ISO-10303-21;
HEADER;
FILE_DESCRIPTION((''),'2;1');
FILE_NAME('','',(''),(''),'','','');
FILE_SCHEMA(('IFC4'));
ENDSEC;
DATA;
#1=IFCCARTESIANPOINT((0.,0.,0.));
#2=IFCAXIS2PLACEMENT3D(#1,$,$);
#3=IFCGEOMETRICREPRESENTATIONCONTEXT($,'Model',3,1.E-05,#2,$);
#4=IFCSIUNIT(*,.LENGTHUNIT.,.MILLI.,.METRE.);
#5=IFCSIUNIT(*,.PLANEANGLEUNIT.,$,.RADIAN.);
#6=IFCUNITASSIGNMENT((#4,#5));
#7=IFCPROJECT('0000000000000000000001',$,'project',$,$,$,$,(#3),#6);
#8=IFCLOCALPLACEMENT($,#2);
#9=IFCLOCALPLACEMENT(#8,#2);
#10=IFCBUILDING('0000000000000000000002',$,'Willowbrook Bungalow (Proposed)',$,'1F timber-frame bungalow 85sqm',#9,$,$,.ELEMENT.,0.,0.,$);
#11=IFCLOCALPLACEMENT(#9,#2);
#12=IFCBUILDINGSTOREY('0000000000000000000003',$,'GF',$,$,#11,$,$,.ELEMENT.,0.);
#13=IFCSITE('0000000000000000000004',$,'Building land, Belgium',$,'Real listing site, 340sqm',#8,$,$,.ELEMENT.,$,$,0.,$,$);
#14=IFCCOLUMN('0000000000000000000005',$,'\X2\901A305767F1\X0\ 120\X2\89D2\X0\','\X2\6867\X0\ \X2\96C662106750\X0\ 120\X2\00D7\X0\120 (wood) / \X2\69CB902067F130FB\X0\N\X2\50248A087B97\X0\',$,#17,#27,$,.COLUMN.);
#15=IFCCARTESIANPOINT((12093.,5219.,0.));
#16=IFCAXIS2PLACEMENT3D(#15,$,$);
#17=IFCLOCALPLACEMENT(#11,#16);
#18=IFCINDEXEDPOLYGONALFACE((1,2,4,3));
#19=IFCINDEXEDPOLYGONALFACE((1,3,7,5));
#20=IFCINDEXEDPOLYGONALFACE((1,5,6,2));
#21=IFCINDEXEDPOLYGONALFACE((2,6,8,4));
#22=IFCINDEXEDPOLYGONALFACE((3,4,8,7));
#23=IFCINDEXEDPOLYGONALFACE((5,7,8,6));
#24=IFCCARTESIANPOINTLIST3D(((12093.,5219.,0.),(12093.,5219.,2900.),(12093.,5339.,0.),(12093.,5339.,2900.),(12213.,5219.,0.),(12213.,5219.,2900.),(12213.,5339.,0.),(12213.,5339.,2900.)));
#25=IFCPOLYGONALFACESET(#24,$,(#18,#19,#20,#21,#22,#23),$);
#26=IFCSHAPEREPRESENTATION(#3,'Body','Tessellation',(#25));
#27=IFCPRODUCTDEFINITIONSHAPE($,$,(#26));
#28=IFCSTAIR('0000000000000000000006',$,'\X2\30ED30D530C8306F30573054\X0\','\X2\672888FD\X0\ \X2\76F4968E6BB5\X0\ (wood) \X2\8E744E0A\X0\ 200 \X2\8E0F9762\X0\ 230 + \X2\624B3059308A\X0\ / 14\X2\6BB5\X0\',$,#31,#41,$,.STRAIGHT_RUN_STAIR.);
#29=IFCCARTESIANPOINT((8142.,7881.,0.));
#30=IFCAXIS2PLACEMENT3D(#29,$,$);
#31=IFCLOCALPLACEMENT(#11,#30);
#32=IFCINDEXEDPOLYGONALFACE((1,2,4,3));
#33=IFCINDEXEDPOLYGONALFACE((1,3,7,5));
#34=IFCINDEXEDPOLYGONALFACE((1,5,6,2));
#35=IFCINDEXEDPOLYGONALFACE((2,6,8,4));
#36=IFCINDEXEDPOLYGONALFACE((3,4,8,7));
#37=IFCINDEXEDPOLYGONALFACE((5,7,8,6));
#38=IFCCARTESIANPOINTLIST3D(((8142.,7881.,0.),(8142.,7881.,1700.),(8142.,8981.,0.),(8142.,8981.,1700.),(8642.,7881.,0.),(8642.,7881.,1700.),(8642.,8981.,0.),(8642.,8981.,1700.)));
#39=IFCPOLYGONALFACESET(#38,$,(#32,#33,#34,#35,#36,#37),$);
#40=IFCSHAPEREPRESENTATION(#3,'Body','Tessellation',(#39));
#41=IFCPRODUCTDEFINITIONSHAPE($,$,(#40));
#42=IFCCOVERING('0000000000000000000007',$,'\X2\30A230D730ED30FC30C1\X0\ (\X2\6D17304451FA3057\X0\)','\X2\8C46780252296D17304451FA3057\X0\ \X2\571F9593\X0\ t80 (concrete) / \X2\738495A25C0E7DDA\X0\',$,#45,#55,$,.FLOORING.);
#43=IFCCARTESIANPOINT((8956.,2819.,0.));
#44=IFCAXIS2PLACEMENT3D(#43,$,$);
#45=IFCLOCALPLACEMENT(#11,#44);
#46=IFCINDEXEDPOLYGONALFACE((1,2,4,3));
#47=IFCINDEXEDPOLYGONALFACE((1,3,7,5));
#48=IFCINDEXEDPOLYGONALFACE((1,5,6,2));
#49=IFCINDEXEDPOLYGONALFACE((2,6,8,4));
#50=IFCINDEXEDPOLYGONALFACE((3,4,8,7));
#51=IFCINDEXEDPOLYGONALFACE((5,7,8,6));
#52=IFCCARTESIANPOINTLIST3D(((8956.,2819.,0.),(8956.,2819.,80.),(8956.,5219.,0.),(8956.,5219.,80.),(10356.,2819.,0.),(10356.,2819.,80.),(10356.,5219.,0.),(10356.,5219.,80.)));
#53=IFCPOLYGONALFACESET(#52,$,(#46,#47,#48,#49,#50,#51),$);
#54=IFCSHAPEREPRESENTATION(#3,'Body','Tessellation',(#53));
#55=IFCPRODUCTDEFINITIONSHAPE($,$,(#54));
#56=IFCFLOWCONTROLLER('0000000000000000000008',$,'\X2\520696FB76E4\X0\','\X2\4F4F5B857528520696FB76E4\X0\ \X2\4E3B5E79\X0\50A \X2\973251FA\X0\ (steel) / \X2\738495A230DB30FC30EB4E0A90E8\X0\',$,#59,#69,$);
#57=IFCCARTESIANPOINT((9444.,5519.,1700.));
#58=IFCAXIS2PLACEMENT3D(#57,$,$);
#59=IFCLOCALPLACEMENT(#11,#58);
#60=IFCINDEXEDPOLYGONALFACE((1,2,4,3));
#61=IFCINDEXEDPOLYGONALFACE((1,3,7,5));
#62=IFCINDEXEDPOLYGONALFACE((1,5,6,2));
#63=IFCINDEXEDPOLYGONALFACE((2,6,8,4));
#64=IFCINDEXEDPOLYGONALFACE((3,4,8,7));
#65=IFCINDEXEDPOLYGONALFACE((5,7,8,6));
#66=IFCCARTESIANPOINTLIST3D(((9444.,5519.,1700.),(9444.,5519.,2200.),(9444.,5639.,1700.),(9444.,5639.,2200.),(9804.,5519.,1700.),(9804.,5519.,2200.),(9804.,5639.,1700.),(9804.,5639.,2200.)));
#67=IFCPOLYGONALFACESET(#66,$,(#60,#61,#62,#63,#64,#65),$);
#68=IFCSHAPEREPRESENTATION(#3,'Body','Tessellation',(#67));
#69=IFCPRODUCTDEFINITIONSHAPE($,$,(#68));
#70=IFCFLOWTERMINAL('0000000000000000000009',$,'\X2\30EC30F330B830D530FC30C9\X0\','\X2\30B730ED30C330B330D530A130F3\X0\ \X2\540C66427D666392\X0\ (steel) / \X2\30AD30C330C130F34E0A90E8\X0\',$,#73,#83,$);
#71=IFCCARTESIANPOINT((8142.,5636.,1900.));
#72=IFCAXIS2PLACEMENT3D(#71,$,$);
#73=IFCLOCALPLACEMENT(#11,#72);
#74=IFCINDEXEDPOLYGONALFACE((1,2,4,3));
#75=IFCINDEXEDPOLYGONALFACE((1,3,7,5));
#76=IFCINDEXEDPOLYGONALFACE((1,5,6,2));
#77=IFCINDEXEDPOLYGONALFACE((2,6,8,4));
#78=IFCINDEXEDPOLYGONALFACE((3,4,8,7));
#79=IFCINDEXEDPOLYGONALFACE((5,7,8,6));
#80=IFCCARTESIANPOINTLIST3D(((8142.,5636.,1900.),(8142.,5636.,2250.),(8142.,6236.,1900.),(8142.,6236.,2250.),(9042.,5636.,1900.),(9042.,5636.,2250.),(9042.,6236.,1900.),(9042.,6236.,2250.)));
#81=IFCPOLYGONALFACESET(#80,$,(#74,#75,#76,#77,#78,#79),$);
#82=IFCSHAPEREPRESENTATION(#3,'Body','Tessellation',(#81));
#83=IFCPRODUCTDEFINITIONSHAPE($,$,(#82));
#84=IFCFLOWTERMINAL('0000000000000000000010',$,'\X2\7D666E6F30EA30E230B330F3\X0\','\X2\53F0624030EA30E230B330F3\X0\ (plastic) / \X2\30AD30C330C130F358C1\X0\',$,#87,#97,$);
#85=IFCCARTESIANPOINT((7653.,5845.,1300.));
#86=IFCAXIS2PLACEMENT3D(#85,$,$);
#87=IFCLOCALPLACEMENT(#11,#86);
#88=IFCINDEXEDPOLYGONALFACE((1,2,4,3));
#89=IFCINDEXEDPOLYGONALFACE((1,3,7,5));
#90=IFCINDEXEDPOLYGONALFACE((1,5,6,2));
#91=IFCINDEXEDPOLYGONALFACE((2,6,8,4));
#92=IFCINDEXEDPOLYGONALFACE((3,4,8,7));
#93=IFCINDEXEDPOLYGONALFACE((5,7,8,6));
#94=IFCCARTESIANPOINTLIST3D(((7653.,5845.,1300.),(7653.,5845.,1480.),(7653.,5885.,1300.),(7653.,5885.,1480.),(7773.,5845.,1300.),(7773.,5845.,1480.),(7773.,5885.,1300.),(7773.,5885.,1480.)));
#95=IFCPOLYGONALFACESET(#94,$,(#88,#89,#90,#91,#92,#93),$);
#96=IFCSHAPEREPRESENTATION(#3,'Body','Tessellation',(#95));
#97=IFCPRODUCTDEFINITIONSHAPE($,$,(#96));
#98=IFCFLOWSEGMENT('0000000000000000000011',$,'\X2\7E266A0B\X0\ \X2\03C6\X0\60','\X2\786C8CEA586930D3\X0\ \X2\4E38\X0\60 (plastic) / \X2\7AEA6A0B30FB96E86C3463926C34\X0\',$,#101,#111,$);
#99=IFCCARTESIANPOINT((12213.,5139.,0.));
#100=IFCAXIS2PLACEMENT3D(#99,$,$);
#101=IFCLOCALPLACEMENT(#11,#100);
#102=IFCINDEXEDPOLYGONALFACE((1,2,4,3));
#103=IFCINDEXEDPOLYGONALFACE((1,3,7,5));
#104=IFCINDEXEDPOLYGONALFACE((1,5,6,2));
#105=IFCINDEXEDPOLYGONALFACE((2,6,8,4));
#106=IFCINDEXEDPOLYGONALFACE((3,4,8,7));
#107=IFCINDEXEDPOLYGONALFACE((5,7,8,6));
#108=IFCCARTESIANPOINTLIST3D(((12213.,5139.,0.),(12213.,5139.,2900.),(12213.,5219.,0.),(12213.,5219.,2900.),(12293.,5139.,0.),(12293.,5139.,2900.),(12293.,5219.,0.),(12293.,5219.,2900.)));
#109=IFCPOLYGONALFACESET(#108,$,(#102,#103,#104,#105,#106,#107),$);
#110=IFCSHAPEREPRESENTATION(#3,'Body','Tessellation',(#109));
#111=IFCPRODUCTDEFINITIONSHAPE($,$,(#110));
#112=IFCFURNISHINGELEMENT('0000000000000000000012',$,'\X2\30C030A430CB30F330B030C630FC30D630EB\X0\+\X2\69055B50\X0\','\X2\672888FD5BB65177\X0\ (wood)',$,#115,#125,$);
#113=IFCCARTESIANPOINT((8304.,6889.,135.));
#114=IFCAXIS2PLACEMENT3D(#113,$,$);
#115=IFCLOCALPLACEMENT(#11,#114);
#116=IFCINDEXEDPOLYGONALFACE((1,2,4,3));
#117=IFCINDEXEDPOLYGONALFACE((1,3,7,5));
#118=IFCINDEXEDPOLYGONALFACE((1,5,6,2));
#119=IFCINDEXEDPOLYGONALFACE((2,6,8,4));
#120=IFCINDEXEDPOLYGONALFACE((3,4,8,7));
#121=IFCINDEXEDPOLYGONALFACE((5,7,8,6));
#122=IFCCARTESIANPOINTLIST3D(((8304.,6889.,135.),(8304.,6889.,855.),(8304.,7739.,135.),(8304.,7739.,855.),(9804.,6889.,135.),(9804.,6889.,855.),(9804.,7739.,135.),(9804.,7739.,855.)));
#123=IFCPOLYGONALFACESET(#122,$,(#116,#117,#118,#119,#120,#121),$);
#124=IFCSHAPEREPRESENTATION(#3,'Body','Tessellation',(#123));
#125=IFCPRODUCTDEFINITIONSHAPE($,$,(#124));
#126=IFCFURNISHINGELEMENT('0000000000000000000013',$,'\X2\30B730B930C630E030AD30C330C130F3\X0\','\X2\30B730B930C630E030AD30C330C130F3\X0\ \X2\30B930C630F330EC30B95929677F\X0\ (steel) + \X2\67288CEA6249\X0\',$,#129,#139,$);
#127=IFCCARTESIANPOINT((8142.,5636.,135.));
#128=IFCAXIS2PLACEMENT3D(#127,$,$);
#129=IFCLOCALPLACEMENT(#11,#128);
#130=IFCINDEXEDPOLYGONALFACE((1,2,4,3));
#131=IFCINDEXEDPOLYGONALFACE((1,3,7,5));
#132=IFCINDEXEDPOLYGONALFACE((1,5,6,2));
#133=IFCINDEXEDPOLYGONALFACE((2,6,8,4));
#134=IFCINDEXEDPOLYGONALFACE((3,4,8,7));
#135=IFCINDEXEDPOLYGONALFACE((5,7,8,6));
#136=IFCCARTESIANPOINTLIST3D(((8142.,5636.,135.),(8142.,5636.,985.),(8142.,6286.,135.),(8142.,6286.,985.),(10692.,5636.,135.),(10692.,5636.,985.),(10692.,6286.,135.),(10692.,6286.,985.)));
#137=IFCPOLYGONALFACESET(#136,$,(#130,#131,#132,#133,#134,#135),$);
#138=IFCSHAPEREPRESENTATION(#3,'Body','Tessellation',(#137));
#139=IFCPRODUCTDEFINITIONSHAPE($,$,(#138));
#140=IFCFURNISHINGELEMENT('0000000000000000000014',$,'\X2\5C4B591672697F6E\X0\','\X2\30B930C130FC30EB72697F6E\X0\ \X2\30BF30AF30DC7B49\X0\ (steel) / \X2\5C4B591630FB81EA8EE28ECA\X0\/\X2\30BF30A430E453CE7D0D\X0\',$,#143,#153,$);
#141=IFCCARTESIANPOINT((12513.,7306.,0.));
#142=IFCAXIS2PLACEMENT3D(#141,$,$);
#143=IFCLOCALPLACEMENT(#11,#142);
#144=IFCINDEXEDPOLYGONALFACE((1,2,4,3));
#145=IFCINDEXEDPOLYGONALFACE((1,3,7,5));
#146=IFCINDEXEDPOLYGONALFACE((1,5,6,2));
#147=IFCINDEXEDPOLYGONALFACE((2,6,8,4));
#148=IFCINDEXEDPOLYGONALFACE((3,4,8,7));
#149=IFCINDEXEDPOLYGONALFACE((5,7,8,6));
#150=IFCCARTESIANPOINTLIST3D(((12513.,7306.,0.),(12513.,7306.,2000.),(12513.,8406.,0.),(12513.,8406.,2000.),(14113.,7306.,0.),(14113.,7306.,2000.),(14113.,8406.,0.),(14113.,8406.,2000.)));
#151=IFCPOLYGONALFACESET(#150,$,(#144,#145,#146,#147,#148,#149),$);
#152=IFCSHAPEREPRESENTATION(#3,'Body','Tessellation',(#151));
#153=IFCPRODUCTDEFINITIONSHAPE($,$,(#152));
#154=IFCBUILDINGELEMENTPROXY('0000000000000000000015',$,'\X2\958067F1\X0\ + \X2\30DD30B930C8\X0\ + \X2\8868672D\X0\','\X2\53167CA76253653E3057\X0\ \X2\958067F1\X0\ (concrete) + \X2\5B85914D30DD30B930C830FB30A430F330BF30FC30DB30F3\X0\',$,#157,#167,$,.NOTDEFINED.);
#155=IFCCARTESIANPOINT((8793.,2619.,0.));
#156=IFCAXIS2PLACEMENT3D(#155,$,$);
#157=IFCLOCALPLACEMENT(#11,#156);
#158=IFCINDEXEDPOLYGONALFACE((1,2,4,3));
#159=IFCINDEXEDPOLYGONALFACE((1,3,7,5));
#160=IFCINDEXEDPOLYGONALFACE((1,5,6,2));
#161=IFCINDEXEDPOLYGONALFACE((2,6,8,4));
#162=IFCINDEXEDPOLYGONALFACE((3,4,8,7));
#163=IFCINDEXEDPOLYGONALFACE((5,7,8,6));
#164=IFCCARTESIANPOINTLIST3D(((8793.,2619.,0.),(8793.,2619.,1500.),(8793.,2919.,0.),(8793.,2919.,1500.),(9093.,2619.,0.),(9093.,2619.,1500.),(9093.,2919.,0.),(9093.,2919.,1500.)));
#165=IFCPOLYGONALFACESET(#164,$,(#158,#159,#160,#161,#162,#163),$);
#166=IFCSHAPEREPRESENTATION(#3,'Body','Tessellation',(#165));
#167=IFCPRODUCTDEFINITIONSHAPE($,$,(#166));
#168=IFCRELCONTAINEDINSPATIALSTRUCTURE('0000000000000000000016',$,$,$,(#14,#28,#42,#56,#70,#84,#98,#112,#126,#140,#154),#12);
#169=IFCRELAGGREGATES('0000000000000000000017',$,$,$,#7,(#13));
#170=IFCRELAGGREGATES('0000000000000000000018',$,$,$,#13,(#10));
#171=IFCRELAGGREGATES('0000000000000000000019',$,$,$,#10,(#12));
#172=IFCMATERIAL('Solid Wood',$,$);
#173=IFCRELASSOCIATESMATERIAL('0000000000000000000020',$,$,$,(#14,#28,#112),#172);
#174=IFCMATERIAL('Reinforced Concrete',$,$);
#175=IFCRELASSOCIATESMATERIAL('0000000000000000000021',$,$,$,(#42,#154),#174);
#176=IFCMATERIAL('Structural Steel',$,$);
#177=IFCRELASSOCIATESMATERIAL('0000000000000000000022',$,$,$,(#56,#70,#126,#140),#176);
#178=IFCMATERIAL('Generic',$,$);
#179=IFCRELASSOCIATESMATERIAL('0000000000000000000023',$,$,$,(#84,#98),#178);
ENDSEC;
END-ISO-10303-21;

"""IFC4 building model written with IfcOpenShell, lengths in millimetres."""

from ifc_helpers import new_model, si_unit, frame, frame_2d, origin, place, context, project, spatial, rectangle, extrude, material, element, save


model = new_model("IFC4")

# Units and contexts
model_context = context("Model", 3, precision=1e-05, world=origin())
ifc_project = project(units=[si_unit("LENGTHUNIT", "METRE", prefix="MILLI"), si_unit("PLANEANGLEUNIT", "RADIAN")], contexts=[model_context])

# Site, building, storey
site_placement = place(None, origin())
site = spatial("IfcSite", under=ifc_project, at=site_placement, Name="Building land, Belgium", ObjectType="Real listing site, 340sqm", CompositionType="ELEMENT", RefElevation=0.0)
building_placement = place(site_placement, origin())
building = spatial("IfcBuilding", under=site, at=building_placement, Name="Willowbrook Bungalow (Proposed)", ObjectType="1F timber-frame bungalow 85sqm", CompositionType="ELEMENT", ElevationOfRefHeight=0.0, ElevationOfTerrain=0.0)
storey_placement = place(building_placement, origin())
storey = spatial("IfcBuildingStorey", under=building, at=storey_placement, Name="GF", CompositionType="ELEMENT", Elevation=0.0)

# Column
ifc_material_1 = material(Name="Solid Wood")
column_1_placement = place(storey_placement, frame((12093.0, 5219.0, 0.0)))
element("IfcColumn", 1, at=column_1_placement, inside=storey, material=ifc_material_1, Name="通し柱 120角", Description="桧 集成材 120×120 (wood) / 構造柱・N値計算", PredefinedType="COLUMN", context=model_context, shape_type="SweptSolid", body=[
    extrude(rectangle(XDim=120.0, YDim=120.0, at=frame_2d((60.0, 60.0))), frame((12093.0, 5219.0, 0.0)), (0.0, 0.0, 1.0), 2900.0),
])

# Stair
stair_placement = place(storey_placement, frame((8142.0, 7881.0, 0.0)))
element("IfcStair", 2, at=stair_placement, inside=storey, material=ifc_material_1, Name="ロフトはしご", Description="木製 直階段 (wood) 蹴上 200 踏面 230 + 手すり / 14段", PredefinedType="STRAIGHT_RUN_STAIR", context=model_context, shape_type="SweptSolid", body=[
    extrude(rectangle(XDim=500.0, YDim=1100.0, at=frame_2d((250.0, 550.0))), frame((8142.0, 7881.0, 0.0)), (0.0, 0.0, 1.0), 1700.0),
])

# Covering
ifc_material_2 = material(Name="Reinforced Concrete")
covering_placement = place(storey_placement, frame((8956.0, 2819.0, 0.0)))
element("IfcCovering", 3, at=covering_placement, inside=storey, material=ifc_material_2, Name="アプローチ (洗い出し)", Description="豆砂利洗い出し 土間 t80 (concrete) / 玄関導線", PredefinedType="FLOORING", context=model_context, shape_type="SweptSolid", body=[
    extrude(rectangle(XDim=1400.0, YDim=2400.0, at=frame_2d((700.0, 1200.0))), frame((8956.0, 2819.0, 0.0)), (0.0, 0.0, 1.0), 80.0),
])

# Flow controller
ifc_material_3 = material(Name="Structural Steel")
flow_controller_placement = place(storey_placement, frame((9444.0, 5519.0, 1700.0)))
element("IfcFlowController", 4, at=flow_controller_placement, inside=storey, material=ifc_material_3, Name="分電盤", Description="住宅用分電盤 主幹50A 露出 (steel) / 玄関ホール上部", context=model_context, shape_type="SweptSolid", body=[
    extrude(rectangle(XDim=360.0, YDim=120.0, at=frame_2d((180.0, 60.0))), frame((9444.0, 5519.0, 1700.0)), (0.0, 0.0, 1.0), 500.0),
])

# Flow terminals
flow_terminal_1_placement = place(storey_placement, frame((8142.0, 5636.0, 1900.0)))
element("IfcFlowTerminal", 5, at=flow_terminal_1_placement, inside=storey, material=ifc_material_3, Name="レンジフード", Description="シロッコファン 同時給排 (steel) / キッチン上部", context=model_context, shape_type="SweptSolid", body=[
    extrude(rectangle(XDim=900.0, YDim=600.0, at=frame_2d((450.0, 300.0))), frame((8142.0, 5636.0, 1900.0)), (0.0, 0.0, 1.0), 350.0),
])
ifc_material_4 = material(Name="Generic")
flow_terminal_2_placement = place(storey_placement, frame((7653.0, 5845.0, 1300.0)))
element("IfcFlowTerminal", 6, at=flow_terminal_2_placement, inside=storey, material=ifc_material_4, Name="給湯リモコン", Description="台所リモコン (plastic) / キッチン壁", context=model_context, shape_type="SweptSolid", body=[
    extrude(rectangle(XDim=120.0, YDim=40.0, at=frame_2d((60.0, 20.0))), frame((7653.0, 5845.0, 1300.0)), (0.0, 0.0, 1.0), 180.0),
])

# Flow segment
flow_segment_placement = place(storey_placement, frame((12213.0, 5139.0, 0.0)))
element("IfcFlowSegment", 7, at=flow_segment_placement, inside=storey, material=ifc_material_4, Name="縦樋 φ60", Description="硬質塩ビ 丸60 (plastic) / 竪樋・雨水排水", context=model_context, shape_type="SweptSolid", body=[
    extrude(rectangle(XDim=80.0, YDim=80.0, at=frame_2d((40.0, 40.0))), frame((12213.0, 5139.0, 0.0)), (0.0, 0.0, 1.0), 2900.0),
])

# Furnishing elements
furnishing_1_placement = place(storey_placement, frame((8304.0, 6889.0, 135.0)))
element("IfcFurnishingElement", 8, at=furnishing_1_placement, inside=storey, material=ifc_material_1, Name="ダイニングテーブル+椅子", Description="木製家具 (wood)", context=model_context, shape_type="SweptSolid", body=[
    extrude(rectangle(XDim=1500.0, YDim=850.0, at=frame_2d((750.0, 425.0))), frame((8304.0, 6889.0, 135.0)), (0.0, 0.0, 1.0), 720.0),
])
furnishing_2_placement = place(storey_placement, frame((8142.0, 5636.0, 135.0)))
element("IfcFurnishingElement", 9, at=furnishing_2_placement, inside=storey, material=ifc_material_3, Name="システムキッチン", Description="システムキッチン ステンレス天板 (steel) + 木質扉", context=model_context, shape_type="SweptSolid", body=[
    extrude(rectangle(XDim=2550.0, YDim=650.0, at=frame_2d((1275.0, 325.0))), frame((8142.0, 5636.0, 135.0)), (0.0, 0.0, 1.0), 850.0),
])
furnishing_3_placement = place(storey_placement, frame((12513.0, 7306.0, 0.0)))
element("IfcFurnishingElement", 10, at=furnishing_3_placement, inside=storey, material=ifc_material_3, Name="屋外物置", Description="スチール物置 タクボ等 (steel) / 屋外・自転車/タイヤ収納", context=model_context, shape_type="SweptSolid", body=[
    extrude(rectangle(XDim=1600.0, YDim=1100.0, at=frame_2d((800.0, 550.0))), frame((12513.0, 7306.0, 0.0)), (0.0, 0.0, 1.0), 2000.0),
])

# Building element proxy
proxy_placement = place(storey_placement, frame((8793.0, 2619.0, 0.0)))
element("IfcBuildingElementProxy", 11, at=proxy_placement, inside=storey, material=ifc_material_2, Name="門柱 + ポスト + 表札", Description="化粧打放し 門柱 (concrete) + 宅配ポスト・インターホン", PredefinedType="NOTDEFINED", context=model_context, shape_type="SweptSolid", body=[
    extrude(rectangle(XDim=300.0, YDim=300.0, at=frame_2d((150.0, 150.0))), frame((8793.0, 2619.0, 0.0)), (0.0, 0.0, 1.0), 1500.0),
])

save(model, "model.ifc")
